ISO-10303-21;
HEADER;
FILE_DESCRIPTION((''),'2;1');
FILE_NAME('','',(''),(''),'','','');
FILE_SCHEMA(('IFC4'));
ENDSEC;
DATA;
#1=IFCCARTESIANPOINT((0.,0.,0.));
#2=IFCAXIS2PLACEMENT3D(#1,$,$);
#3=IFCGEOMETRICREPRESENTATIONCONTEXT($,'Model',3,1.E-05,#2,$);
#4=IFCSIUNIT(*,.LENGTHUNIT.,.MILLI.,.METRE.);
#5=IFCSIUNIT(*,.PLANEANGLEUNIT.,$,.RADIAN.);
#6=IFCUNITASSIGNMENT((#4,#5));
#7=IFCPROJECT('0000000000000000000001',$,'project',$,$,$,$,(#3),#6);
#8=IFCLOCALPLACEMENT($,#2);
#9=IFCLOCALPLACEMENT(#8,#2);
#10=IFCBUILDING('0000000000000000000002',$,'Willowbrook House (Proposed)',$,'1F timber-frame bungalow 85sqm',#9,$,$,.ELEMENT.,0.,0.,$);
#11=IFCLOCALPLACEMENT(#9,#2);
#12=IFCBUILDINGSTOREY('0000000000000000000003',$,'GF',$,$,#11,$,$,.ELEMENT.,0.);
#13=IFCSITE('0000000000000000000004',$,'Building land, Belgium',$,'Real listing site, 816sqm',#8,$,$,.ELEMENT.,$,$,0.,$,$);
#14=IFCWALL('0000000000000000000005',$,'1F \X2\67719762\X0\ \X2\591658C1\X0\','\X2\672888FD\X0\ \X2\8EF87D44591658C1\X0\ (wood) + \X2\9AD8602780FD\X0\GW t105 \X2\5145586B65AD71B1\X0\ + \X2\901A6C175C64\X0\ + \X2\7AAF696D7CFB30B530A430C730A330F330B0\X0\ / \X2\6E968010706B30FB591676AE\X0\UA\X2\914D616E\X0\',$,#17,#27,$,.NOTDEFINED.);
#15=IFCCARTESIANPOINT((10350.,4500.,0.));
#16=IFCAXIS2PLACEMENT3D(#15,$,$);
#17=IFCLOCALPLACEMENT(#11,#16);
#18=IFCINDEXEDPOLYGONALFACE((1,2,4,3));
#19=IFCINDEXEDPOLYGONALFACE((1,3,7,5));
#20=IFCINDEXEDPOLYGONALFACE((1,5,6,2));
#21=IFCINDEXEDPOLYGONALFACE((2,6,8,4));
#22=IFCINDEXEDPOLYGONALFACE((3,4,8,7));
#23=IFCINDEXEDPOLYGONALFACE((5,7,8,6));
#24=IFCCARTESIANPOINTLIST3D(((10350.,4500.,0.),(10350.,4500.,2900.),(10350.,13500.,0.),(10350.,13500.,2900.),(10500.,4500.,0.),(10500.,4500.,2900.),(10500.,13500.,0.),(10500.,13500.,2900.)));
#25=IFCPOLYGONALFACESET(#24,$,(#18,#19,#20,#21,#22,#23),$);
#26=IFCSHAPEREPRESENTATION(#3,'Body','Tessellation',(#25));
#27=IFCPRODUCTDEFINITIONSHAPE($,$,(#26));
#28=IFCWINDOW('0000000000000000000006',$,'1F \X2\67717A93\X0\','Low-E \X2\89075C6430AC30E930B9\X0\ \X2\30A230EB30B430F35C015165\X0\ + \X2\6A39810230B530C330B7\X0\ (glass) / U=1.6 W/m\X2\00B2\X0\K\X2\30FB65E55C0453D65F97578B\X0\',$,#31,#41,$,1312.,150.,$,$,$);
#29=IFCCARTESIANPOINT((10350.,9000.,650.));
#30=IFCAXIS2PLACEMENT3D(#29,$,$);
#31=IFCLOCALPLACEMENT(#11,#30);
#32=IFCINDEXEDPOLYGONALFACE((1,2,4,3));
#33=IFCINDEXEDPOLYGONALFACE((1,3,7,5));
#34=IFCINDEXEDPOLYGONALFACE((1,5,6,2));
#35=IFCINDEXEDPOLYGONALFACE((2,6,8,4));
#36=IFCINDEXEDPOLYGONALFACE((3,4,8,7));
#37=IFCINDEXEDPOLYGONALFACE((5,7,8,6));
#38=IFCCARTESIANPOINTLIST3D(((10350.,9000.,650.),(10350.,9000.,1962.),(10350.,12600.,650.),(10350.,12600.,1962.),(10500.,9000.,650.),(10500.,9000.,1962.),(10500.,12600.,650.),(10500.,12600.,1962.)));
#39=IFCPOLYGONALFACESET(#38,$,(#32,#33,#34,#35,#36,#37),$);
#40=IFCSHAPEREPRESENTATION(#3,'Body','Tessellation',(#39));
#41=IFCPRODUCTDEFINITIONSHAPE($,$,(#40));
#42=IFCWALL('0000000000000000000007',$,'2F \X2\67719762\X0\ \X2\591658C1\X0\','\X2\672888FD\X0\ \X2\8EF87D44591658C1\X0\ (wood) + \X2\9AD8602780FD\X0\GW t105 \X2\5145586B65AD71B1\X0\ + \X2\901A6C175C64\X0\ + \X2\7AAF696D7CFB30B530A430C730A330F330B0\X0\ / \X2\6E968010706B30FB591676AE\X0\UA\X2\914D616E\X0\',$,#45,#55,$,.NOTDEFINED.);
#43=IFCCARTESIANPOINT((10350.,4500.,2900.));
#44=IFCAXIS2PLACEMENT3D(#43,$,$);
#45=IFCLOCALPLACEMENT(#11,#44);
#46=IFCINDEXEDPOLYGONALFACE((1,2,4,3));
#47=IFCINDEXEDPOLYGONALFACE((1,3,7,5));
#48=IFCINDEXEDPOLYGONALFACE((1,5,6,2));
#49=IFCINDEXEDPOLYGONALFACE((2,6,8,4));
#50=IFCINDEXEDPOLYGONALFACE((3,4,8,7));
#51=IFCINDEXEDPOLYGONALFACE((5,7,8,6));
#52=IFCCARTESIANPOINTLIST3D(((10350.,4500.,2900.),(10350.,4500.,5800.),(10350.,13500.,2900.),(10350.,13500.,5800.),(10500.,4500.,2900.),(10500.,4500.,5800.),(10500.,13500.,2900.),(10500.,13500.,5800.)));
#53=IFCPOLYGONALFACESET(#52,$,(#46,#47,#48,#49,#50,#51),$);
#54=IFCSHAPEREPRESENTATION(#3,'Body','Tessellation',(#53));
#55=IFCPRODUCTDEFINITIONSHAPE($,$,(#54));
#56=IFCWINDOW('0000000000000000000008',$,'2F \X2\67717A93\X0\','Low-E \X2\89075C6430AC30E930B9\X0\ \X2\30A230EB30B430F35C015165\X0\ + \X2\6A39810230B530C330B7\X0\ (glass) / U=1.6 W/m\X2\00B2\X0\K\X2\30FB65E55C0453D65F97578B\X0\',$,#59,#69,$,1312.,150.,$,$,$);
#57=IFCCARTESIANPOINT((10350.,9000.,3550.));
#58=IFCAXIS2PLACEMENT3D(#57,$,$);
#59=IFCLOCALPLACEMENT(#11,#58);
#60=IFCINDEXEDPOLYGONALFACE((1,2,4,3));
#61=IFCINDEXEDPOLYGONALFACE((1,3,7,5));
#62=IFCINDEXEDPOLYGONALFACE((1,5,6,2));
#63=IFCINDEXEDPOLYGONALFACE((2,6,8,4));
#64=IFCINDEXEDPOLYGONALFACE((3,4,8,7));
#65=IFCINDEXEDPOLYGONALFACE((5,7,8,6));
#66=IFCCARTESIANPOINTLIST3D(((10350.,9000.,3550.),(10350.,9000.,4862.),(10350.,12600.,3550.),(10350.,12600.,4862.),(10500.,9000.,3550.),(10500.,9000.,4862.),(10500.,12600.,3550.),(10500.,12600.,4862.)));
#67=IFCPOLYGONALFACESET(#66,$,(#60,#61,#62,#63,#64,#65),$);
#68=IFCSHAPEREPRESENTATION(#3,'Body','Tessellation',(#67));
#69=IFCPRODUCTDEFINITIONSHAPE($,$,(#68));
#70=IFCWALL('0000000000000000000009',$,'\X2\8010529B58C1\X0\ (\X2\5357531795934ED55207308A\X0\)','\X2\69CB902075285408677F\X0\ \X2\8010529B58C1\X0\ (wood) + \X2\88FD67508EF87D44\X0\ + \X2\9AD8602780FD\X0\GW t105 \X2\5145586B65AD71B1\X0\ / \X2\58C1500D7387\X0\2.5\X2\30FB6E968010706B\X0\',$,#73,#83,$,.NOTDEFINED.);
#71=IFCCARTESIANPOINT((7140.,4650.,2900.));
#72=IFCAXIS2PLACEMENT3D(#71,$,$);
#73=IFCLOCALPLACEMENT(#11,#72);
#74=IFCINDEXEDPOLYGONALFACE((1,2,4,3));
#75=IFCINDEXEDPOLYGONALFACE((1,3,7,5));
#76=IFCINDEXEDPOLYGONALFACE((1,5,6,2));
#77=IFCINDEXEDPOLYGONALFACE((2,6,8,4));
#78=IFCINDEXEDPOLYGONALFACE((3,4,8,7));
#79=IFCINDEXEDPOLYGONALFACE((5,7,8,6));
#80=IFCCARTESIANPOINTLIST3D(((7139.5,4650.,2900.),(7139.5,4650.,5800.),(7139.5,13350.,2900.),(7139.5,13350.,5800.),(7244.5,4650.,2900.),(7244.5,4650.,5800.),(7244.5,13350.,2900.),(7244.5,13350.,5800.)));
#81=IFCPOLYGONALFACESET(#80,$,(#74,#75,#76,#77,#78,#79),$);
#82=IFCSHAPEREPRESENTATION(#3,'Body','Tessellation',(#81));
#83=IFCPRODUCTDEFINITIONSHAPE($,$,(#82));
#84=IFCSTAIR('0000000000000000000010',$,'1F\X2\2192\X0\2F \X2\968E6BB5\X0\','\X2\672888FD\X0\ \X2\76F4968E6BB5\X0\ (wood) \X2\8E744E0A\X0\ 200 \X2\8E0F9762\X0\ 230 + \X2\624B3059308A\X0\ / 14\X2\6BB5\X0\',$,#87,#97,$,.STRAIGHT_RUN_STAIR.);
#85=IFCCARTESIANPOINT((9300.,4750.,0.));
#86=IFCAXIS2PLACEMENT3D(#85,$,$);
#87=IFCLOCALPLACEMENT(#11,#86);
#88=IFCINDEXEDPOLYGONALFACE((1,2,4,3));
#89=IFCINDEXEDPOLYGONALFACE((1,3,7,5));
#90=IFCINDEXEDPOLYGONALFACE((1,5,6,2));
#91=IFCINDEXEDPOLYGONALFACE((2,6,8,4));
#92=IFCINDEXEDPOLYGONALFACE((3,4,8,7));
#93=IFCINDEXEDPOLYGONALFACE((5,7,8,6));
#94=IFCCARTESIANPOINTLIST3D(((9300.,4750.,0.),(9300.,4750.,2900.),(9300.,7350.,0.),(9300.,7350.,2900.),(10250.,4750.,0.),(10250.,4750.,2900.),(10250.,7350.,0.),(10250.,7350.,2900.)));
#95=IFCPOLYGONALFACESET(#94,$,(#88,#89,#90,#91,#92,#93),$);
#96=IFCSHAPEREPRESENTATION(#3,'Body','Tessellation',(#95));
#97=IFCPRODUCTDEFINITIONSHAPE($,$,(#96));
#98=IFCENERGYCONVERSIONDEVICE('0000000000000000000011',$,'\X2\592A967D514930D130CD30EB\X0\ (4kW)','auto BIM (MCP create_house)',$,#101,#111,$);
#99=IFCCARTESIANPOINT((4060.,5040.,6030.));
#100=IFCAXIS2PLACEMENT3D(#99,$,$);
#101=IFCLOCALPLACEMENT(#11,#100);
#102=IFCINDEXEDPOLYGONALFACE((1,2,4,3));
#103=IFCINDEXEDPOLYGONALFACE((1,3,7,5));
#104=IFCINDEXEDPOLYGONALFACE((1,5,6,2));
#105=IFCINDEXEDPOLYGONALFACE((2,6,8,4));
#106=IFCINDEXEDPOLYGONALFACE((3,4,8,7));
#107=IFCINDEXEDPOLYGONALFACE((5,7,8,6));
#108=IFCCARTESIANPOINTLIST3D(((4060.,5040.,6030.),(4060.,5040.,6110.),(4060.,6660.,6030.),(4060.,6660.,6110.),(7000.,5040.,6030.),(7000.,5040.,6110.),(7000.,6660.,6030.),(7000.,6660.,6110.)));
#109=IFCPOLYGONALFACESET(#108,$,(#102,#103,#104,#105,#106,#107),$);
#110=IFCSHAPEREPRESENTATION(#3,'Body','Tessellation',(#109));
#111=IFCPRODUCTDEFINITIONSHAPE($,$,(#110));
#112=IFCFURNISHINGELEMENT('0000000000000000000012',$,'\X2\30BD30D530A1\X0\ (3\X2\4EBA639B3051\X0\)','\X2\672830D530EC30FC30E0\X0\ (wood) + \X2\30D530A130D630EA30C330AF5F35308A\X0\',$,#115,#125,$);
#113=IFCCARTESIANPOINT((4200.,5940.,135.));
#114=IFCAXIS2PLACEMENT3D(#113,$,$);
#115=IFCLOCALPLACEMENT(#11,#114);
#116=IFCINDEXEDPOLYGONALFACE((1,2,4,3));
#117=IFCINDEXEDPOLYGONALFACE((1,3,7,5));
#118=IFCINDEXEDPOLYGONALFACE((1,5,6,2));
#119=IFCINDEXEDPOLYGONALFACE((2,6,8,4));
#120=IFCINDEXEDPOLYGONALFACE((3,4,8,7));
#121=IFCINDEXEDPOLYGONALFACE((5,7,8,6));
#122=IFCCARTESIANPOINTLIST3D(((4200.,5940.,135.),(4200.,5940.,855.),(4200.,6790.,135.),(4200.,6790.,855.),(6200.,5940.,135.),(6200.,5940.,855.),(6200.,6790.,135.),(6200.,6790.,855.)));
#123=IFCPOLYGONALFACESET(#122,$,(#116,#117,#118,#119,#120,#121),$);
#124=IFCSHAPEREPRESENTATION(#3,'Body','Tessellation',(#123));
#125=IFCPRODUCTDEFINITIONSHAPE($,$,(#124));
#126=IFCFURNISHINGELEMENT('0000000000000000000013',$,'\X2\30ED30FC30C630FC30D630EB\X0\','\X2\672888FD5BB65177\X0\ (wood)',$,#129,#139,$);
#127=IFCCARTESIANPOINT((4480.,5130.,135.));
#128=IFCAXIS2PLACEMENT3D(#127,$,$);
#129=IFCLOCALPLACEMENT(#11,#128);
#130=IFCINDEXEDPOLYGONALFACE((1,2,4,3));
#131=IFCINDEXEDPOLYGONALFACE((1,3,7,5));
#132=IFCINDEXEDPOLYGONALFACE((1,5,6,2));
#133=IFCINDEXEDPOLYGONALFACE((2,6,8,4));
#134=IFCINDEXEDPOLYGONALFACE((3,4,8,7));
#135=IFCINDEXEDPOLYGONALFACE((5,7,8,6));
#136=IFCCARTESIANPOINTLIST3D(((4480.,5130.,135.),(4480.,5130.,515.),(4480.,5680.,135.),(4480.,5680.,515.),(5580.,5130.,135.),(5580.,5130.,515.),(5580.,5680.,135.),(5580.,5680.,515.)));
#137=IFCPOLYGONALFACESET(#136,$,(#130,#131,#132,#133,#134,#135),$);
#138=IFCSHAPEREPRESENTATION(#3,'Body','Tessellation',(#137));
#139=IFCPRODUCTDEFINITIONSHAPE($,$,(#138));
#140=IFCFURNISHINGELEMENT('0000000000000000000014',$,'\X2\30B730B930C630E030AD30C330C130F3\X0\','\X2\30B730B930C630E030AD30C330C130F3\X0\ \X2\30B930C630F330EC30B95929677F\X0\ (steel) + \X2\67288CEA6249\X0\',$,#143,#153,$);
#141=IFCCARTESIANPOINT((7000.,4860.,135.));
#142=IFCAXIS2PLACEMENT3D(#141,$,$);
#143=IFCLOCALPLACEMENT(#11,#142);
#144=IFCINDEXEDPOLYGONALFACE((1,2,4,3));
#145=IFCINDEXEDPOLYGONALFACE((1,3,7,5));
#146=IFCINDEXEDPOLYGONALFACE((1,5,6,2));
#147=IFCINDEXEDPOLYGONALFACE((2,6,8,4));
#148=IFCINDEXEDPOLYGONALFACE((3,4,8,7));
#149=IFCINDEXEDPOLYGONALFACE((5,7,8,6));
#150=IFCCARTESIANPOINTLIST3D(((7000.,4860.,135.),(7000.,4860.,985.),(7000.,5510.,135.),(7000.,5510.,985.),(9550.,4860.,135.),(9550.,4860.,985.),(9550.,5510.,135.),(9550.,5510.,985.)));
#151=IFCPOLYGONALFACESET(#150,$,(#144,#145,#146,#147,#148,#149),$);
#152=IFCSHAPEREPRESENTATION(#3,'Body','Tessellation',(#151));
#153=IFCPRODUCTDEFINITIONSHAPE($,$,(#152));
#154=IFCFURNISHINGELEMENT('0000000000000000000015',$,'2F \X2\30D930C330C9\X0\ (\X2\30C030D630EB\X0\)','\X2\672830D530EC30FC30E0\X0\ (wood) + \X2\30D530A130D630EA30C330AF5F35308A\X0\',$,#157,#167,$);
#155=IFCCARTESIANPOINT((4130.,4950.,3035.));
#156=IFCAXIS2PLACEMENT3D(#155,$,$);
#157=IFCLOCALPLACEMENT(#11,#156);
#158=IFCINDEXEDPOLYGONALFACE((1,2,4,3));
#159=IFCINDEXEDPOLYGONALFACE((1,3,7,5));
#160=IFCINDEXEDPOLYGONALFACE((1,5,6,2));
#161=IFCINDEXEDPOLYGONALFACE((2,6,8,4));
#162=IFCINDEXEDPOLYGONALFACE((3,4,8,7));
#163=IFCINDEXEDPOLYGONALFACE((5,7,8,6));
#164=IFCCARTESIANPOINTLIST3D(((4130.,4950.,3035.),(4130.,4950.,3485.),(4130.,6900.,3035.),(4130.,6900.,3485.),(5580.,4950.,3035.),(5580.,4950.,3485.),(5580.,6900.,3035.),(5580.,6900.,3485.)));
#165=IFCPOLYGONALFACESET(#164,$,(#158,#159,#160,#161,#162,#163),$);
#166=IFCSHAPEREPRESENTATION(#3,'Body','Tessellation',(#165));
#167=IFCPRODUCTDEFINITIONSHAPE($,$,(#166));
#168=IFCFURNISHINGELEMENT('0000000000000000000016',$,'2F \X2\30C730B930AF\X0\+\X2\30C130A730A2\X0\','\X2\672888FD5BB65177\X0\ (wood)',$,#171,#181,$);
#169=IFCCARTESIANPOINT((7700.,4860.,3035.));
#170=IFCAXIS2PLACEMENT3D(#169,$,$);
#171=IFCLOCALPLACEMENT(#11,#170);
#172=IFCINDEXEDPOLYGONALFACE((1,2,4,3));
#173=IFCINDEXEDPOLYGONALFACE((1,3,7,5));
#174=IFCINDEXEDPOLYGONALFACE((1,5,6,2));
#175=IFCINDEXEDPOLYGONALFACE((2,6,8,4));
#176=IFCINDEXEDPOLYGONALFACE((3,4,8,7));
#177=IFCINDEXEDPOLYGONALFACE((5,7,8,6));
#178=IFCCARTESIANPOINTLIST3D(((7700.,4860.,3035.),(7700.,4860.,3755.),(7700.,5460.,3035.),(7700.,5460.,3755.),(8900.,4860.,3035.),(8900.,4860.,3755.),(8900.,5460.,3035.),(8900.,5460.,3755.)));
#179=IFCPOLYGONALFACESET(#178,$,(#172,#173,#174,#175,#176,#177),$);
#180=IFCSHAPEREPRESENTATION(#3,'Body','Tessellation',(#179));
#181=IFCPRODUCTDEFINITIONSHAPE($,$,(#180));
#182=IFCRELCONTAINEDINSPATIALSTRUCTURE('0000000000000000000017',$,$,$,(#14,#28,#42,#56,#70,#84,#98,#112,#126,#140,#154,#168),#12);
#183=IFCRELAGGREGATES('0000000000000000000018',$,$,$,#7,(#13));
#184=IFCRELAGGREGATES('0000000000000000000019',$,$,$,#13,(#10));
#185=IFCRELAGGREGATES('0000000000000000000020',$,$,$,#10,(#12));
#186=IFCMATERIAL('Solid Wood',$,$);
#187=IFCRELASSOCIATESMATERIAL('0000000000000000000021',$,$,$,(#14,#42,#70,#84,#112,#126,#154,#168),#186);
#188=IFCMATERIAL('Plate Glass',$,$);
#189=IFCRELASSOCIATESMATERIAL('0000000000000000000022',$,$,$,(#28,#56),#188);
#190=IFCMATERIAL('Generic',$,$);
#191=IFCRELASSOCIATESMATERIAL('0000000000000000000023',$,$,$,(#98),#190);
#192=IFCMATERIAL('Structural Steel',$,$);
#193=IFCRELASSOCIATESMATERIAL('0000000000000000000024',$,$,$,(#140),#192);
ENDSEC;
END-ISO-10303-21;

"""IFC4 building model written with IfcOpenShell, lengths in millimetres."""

from ifc_helpers import new_model, si_unit, frame, frame_2d, origin, place, context, project, spatial, rectangle, extrude, material, element, fill, save


model = new_model("IFC4")

# Units and contexts
model_context = context("Model", 3, precision=1e-05, world=origin())
ifc_project = project(units=[si_unit("LENGTHUNIT", "METRE", prefix="MILLI"), si_unit("PLANEANGLEUNIT", "RADIAN")], contexts=[model_context])

# Site, building, storey
site_placement = place(None, origin())
site = spatial("IfcSite", under=ifc_project, at=site_placement, Name="Building land, Belgium", ObjectType="Real listing site, 816sqm", CompositionType="ELEMENT", RefElevation=0.0)
building_placement = place(site_placement, origin())
building = spatial("IfcBuilding", under=site, at=building_placement, Name="Willowbrook House (Proposed)", ObjectType="1F timber-frame bungalow 85sqm", CompositionType="ELEMENT", ElevationOfRefHeight=0.0, ElevationOfTerrain=0.0)
storey_placement = place(building_placement, origin())
storey = spatial("IfcBuildingStorey", under=building, at=storey_placement, Name="GF", CompositionType="ELEMENT", Elevation=0.0)

# Wall, opening, window
ifc_material_1 = material(Name="Solid Wood")
wall_1_placement = place(storey_placement, frame((10350.0, 4500.0, 0.0)))
wall_1 = element("IfcWall", 1, at=wall_1_placement, inside=storey, material=ifc_material_1, Name="1F 東面 外壁", Description="木製 軸組外壁 (wood) + 高性能GW t105 充填断熱 + 通気層 + 窯業系サイディング / 準耐火・外皮UA配慮", PredefinedType="NOTDEFINED", context=model_context, shape_type="SweptSolid", body=[
    extrude(rectangle(XDim=150.0, YDim=9000.0, at=frame_2d((75.0, 4500.0))), frame((10350.0, 4500.0, 0.0)), (0.0, 0.0, 1.0), 2900.0),
])
opening_1_placement = place(storey_placement, frame((10350.0, 9000.0, 650.0)))
opening_1 = element("IfcOpeningElement", 2, at=opening_1_placement, cuts=wall_1, PredefinedType="NOTDEFINED", context=model_context, shape_type="SweptSolid", body=[
    extrude(rectangle(XDim=150.0, YDim=3600.0, at=frame_2d((75.0, 1800.0))), frame((10350.0, 9000.0, 650.0)), (0.0, 0.0, 1.0), 1312.0),
])
ifc_material_2 = material(Name="Plate Glass")
window_1_placement = place(storey_placement, frame((10350.0, 9000.0, 650.0)))
window_1 = element("IfcWindow", 3, at=window_1_placement, inside=storey, material=ifc_material_2, Name="1F 東窓", Description="Low-E 複層ガラス アルゴン封入 + 樹脂サッシ (glass) / U=1.6 W/m²K・日射取得型", OverallHeight=1312.0, OverallWidth=150.0, context=model_context, shape_type="SweptSolid", body=[
    extrude(rectangle(XDim=150.0, YDim=3600.0, at=frame_2d((75.0, 1800.0))), frame((10350.0, 9000.0, 650.0)), (0.0, 0.0, 1.0), 1312.0),
])
fill(opening_1, window_1)

# Wall, opening, window
wall_2_placement = place(storey_placement, frame((10350.0, 4500.0, 2900.0)))
wall_2 = element("IfcWall", 4, at=wall_2_placement, inside=storey, material=ifc_material_1, Name="2F 東面 外壁", Description="木製 軸組外壁 (wood) + 高性能GW t105 充填断熱 + 通気層 + 窯業系サイディング / 準耐火・外皮UA配慮", PredefinedType="NOTDEFINED", context=model_context, shape_type="SweptSolid", body=[
    extrude(rectangle(XDim=150.0, YDim=9000.0, at=frame_2d((75.0, 4500.0))), frame((10350.0, 4500.0, 2900.0)), (0.0, 0.0, 1.0), 2900.0),
])
opening_2_placement = place(storey_placement, frame((10350.0, 9000.0, 3550.0)))
opening_2 = element("IfcOpeningElement", 5, at=opening_2_placement, cuts=wall_2, PredefinedType="NOTDEFINED", context=model_context, shape_type="SweptSolid", body=[
    extrude(rectangle(XDim=150.0, YDim=3600.0, at=frame_2d((75.0, 1800.0))), frame((10350.0, 9000.0, 3550.0)), (0.0, 0.0, 1.0), 1312.0),
])
window_2_placement = place(storey_placement, frame((10350.0, 9000.0, 3550.0)))
window_2 = element("IfcWindow", 6, at=window_2_placement, inside=storey, material=ifc_material_2, Name="2F 東窓", Description="Low-E 複層ガラス アルゴン封入 + 樹脂サッシ (glass) / U=1.6 W/m²K・日射取得型", OverallHeight=1312.0, OverallWidth=150.0, context=model_context, shape_type="SweptSolid", body=[
    extrude(rectangle(XDim=150.0, YDim=3600.0, at=frame_2d((75.0, 1800.0))), frame((10350.0, 9000.0, 3550.0)), (0.0, 0.0, 1.0), 1312.0),
])
fill(opening_2, window_2)

# Wall
wall_3_placement = place(storey_placement, frame((7140.0, 4650.0, 2900.0)))
element("IfcWall", 7, at=wall_3_placement, inside=storey, material=ifc_material_1, Name="耐力壁 (南北間仕切り)", Description="構造用合板 耐力壁 (wood) + 製材軸組 + 高性能GW t105 充填断熱 / 壁倍率2.5・準耐火", PredefinedType="NOTDEFINED", context=model_context, shape_type="SweptSolid", body=[
    extrude(rectangle(XDim=105.0, YDim=8700.0, at=frame_2d((52.0, 4350.0))), frame((7140.0, 4650.0, 2900.0)), (0.0, 0.0, 1.0), 2900.0),
])

# Stair
stair_placement = place(storey_placement, frame((9300.0, 4750.0, 0.0)))
element("IfcStair", 8, at=stair_placement, inside=storey, material=ifc_material_1, Name="1F→2F 階段", Description="木製 直階段 (wood) 蹴上 200 踏面 230 + 手すり / 14段", PredefinedType="STRAIGHT_RUN_STAIR", context=model_context, shape_type="SweptSolid", body=[
    extrude(rectangle(XDim=950.0, YDim=2600.0, at=frame_2d((475.0, 1300.0))), frame((9300.0, 4750.0, 0.0)), (0.0, 0.0, 1.0), 2900.0),
])

# Energy conversion device
ifc_material_3 = material(Name="Generic")
energy_conversion_device_placement = place(storey_placement, frame((4060.0, 5040.0, 6030.0)))
element("IfcEnergyConversionDevice", 9, at=energy_conversion_device_placement, inside=storey, material=ifc_material_3, Name="太陽光パネル (4kW)", Description="auto BIM (MCP create_house)", context=model_context, shape_type="SweptSolid", body=[
    extrude(rectangle(XDim=2940.0, YDim=1620.0, at=frame_2d((1470.0, 810.0))), frame((4060.0, 5040.0, 6030.0)), (0.0, 0.0, 1.0), 80.0),
])

# Furnishing elements
furnishing_1_placement = place(storey_placement, frame((4200.0, 5940.0, 135.0)))
element("IfcFurnishingElement", 10, at=furnishing_1_placement, inside=storey, material=ifc_material_1, Name="ソファ (3人掛け)", Description="木フレーム (wood) + ファブリック張り", context=model_context, shape_type="SweptSolid", body=[
    extrude(rectangle(XDim=2000.0, YDim=850.0, at=frame_2d((1000.0, 425.0))), frame((4200.0, 5940.0, 135.0)), (0.0, 0.0, 1.0), 720.0),
])
furnishing_2_placement = place(storey_placement, frame((4480.0, 5130.0, 135.0)))
element("IfcFurnishingElement", 11, at=furnishing_2_placement, inside=storey, material=ifc_material_1, Name="ローテーブル", Description="木製家具 (wood)", context=model_context, shape_type="SweptSolid", body=[
    extrude(rectangle(XDim=1100.0, YDim=550.0, at=frame_2d((550.0, 275.0))), frame((4480.0, 5130.0, 135.0)), (0.0, 0.0, 1.0), 380.0),
])
ifc_material_4 = material(Name="Structural Steel")
furnishing_3_placement = place(storey_placement, frame((7000.0, 4860.0, 135.0)))
element("IfcFurnishingElement", 12, at=furnishing_3_placement, inside=storey, material=ifc_material_4, Name="システムキッチン", Description="システムキッチン ステンレス天板 (steel) + 木質扉", context=model_context, shape_type="SweptSolid", body=[
    extrude(rectangle(XDim=2550.0, YDim=650.0, at=frame_2d((1275.0, 325.0))), frame((7000.0, 4860.0, 135.0)), (0.0, 0.0, 1.0), 850.0),
])
furnishing_4_placement = place(storey_placement, frame((4130.0, 4950.0, 3035.0)))
element("IfcFurnishingElement", 13, at=furnishing_4_placement, inside=storey, material=ifc_material_1, Name="2F ベッド (ダブル)", Description="木フレーム (wood) + ファブリック張り", context=model_context, shape_type="SweptSolid", body=[
    extrude(rectangle(XDim=1450.0, YDim=1950.0, at=frame_2d((725.0, 975.0))), frame((4130.0, 4950.0, 3035.0)), (0.0, 0.0, 1.0), 450.0),
])
furnishing_5_placement = place(storey_placement, frame((7700.0, 4860.0, 3035.0)))
element("IfcFurnishingElement", 14, at=furnishing_5_placement, inside=storey, material=ifc_material_1, Name="2F デスク+チェア", Description="木製家具 (wood)", context=model_context, shape_type="SweptSolid", body=[
    extrude(rectangle(XDim=1200.0, YDim=600.0, at=frame_2d((600.0, 300.0))), frame((7700.0, 4860.0, 3035.0)), (0.0, 0.0, 1.0), 720.0),
])

save(model, "model.ifc")
